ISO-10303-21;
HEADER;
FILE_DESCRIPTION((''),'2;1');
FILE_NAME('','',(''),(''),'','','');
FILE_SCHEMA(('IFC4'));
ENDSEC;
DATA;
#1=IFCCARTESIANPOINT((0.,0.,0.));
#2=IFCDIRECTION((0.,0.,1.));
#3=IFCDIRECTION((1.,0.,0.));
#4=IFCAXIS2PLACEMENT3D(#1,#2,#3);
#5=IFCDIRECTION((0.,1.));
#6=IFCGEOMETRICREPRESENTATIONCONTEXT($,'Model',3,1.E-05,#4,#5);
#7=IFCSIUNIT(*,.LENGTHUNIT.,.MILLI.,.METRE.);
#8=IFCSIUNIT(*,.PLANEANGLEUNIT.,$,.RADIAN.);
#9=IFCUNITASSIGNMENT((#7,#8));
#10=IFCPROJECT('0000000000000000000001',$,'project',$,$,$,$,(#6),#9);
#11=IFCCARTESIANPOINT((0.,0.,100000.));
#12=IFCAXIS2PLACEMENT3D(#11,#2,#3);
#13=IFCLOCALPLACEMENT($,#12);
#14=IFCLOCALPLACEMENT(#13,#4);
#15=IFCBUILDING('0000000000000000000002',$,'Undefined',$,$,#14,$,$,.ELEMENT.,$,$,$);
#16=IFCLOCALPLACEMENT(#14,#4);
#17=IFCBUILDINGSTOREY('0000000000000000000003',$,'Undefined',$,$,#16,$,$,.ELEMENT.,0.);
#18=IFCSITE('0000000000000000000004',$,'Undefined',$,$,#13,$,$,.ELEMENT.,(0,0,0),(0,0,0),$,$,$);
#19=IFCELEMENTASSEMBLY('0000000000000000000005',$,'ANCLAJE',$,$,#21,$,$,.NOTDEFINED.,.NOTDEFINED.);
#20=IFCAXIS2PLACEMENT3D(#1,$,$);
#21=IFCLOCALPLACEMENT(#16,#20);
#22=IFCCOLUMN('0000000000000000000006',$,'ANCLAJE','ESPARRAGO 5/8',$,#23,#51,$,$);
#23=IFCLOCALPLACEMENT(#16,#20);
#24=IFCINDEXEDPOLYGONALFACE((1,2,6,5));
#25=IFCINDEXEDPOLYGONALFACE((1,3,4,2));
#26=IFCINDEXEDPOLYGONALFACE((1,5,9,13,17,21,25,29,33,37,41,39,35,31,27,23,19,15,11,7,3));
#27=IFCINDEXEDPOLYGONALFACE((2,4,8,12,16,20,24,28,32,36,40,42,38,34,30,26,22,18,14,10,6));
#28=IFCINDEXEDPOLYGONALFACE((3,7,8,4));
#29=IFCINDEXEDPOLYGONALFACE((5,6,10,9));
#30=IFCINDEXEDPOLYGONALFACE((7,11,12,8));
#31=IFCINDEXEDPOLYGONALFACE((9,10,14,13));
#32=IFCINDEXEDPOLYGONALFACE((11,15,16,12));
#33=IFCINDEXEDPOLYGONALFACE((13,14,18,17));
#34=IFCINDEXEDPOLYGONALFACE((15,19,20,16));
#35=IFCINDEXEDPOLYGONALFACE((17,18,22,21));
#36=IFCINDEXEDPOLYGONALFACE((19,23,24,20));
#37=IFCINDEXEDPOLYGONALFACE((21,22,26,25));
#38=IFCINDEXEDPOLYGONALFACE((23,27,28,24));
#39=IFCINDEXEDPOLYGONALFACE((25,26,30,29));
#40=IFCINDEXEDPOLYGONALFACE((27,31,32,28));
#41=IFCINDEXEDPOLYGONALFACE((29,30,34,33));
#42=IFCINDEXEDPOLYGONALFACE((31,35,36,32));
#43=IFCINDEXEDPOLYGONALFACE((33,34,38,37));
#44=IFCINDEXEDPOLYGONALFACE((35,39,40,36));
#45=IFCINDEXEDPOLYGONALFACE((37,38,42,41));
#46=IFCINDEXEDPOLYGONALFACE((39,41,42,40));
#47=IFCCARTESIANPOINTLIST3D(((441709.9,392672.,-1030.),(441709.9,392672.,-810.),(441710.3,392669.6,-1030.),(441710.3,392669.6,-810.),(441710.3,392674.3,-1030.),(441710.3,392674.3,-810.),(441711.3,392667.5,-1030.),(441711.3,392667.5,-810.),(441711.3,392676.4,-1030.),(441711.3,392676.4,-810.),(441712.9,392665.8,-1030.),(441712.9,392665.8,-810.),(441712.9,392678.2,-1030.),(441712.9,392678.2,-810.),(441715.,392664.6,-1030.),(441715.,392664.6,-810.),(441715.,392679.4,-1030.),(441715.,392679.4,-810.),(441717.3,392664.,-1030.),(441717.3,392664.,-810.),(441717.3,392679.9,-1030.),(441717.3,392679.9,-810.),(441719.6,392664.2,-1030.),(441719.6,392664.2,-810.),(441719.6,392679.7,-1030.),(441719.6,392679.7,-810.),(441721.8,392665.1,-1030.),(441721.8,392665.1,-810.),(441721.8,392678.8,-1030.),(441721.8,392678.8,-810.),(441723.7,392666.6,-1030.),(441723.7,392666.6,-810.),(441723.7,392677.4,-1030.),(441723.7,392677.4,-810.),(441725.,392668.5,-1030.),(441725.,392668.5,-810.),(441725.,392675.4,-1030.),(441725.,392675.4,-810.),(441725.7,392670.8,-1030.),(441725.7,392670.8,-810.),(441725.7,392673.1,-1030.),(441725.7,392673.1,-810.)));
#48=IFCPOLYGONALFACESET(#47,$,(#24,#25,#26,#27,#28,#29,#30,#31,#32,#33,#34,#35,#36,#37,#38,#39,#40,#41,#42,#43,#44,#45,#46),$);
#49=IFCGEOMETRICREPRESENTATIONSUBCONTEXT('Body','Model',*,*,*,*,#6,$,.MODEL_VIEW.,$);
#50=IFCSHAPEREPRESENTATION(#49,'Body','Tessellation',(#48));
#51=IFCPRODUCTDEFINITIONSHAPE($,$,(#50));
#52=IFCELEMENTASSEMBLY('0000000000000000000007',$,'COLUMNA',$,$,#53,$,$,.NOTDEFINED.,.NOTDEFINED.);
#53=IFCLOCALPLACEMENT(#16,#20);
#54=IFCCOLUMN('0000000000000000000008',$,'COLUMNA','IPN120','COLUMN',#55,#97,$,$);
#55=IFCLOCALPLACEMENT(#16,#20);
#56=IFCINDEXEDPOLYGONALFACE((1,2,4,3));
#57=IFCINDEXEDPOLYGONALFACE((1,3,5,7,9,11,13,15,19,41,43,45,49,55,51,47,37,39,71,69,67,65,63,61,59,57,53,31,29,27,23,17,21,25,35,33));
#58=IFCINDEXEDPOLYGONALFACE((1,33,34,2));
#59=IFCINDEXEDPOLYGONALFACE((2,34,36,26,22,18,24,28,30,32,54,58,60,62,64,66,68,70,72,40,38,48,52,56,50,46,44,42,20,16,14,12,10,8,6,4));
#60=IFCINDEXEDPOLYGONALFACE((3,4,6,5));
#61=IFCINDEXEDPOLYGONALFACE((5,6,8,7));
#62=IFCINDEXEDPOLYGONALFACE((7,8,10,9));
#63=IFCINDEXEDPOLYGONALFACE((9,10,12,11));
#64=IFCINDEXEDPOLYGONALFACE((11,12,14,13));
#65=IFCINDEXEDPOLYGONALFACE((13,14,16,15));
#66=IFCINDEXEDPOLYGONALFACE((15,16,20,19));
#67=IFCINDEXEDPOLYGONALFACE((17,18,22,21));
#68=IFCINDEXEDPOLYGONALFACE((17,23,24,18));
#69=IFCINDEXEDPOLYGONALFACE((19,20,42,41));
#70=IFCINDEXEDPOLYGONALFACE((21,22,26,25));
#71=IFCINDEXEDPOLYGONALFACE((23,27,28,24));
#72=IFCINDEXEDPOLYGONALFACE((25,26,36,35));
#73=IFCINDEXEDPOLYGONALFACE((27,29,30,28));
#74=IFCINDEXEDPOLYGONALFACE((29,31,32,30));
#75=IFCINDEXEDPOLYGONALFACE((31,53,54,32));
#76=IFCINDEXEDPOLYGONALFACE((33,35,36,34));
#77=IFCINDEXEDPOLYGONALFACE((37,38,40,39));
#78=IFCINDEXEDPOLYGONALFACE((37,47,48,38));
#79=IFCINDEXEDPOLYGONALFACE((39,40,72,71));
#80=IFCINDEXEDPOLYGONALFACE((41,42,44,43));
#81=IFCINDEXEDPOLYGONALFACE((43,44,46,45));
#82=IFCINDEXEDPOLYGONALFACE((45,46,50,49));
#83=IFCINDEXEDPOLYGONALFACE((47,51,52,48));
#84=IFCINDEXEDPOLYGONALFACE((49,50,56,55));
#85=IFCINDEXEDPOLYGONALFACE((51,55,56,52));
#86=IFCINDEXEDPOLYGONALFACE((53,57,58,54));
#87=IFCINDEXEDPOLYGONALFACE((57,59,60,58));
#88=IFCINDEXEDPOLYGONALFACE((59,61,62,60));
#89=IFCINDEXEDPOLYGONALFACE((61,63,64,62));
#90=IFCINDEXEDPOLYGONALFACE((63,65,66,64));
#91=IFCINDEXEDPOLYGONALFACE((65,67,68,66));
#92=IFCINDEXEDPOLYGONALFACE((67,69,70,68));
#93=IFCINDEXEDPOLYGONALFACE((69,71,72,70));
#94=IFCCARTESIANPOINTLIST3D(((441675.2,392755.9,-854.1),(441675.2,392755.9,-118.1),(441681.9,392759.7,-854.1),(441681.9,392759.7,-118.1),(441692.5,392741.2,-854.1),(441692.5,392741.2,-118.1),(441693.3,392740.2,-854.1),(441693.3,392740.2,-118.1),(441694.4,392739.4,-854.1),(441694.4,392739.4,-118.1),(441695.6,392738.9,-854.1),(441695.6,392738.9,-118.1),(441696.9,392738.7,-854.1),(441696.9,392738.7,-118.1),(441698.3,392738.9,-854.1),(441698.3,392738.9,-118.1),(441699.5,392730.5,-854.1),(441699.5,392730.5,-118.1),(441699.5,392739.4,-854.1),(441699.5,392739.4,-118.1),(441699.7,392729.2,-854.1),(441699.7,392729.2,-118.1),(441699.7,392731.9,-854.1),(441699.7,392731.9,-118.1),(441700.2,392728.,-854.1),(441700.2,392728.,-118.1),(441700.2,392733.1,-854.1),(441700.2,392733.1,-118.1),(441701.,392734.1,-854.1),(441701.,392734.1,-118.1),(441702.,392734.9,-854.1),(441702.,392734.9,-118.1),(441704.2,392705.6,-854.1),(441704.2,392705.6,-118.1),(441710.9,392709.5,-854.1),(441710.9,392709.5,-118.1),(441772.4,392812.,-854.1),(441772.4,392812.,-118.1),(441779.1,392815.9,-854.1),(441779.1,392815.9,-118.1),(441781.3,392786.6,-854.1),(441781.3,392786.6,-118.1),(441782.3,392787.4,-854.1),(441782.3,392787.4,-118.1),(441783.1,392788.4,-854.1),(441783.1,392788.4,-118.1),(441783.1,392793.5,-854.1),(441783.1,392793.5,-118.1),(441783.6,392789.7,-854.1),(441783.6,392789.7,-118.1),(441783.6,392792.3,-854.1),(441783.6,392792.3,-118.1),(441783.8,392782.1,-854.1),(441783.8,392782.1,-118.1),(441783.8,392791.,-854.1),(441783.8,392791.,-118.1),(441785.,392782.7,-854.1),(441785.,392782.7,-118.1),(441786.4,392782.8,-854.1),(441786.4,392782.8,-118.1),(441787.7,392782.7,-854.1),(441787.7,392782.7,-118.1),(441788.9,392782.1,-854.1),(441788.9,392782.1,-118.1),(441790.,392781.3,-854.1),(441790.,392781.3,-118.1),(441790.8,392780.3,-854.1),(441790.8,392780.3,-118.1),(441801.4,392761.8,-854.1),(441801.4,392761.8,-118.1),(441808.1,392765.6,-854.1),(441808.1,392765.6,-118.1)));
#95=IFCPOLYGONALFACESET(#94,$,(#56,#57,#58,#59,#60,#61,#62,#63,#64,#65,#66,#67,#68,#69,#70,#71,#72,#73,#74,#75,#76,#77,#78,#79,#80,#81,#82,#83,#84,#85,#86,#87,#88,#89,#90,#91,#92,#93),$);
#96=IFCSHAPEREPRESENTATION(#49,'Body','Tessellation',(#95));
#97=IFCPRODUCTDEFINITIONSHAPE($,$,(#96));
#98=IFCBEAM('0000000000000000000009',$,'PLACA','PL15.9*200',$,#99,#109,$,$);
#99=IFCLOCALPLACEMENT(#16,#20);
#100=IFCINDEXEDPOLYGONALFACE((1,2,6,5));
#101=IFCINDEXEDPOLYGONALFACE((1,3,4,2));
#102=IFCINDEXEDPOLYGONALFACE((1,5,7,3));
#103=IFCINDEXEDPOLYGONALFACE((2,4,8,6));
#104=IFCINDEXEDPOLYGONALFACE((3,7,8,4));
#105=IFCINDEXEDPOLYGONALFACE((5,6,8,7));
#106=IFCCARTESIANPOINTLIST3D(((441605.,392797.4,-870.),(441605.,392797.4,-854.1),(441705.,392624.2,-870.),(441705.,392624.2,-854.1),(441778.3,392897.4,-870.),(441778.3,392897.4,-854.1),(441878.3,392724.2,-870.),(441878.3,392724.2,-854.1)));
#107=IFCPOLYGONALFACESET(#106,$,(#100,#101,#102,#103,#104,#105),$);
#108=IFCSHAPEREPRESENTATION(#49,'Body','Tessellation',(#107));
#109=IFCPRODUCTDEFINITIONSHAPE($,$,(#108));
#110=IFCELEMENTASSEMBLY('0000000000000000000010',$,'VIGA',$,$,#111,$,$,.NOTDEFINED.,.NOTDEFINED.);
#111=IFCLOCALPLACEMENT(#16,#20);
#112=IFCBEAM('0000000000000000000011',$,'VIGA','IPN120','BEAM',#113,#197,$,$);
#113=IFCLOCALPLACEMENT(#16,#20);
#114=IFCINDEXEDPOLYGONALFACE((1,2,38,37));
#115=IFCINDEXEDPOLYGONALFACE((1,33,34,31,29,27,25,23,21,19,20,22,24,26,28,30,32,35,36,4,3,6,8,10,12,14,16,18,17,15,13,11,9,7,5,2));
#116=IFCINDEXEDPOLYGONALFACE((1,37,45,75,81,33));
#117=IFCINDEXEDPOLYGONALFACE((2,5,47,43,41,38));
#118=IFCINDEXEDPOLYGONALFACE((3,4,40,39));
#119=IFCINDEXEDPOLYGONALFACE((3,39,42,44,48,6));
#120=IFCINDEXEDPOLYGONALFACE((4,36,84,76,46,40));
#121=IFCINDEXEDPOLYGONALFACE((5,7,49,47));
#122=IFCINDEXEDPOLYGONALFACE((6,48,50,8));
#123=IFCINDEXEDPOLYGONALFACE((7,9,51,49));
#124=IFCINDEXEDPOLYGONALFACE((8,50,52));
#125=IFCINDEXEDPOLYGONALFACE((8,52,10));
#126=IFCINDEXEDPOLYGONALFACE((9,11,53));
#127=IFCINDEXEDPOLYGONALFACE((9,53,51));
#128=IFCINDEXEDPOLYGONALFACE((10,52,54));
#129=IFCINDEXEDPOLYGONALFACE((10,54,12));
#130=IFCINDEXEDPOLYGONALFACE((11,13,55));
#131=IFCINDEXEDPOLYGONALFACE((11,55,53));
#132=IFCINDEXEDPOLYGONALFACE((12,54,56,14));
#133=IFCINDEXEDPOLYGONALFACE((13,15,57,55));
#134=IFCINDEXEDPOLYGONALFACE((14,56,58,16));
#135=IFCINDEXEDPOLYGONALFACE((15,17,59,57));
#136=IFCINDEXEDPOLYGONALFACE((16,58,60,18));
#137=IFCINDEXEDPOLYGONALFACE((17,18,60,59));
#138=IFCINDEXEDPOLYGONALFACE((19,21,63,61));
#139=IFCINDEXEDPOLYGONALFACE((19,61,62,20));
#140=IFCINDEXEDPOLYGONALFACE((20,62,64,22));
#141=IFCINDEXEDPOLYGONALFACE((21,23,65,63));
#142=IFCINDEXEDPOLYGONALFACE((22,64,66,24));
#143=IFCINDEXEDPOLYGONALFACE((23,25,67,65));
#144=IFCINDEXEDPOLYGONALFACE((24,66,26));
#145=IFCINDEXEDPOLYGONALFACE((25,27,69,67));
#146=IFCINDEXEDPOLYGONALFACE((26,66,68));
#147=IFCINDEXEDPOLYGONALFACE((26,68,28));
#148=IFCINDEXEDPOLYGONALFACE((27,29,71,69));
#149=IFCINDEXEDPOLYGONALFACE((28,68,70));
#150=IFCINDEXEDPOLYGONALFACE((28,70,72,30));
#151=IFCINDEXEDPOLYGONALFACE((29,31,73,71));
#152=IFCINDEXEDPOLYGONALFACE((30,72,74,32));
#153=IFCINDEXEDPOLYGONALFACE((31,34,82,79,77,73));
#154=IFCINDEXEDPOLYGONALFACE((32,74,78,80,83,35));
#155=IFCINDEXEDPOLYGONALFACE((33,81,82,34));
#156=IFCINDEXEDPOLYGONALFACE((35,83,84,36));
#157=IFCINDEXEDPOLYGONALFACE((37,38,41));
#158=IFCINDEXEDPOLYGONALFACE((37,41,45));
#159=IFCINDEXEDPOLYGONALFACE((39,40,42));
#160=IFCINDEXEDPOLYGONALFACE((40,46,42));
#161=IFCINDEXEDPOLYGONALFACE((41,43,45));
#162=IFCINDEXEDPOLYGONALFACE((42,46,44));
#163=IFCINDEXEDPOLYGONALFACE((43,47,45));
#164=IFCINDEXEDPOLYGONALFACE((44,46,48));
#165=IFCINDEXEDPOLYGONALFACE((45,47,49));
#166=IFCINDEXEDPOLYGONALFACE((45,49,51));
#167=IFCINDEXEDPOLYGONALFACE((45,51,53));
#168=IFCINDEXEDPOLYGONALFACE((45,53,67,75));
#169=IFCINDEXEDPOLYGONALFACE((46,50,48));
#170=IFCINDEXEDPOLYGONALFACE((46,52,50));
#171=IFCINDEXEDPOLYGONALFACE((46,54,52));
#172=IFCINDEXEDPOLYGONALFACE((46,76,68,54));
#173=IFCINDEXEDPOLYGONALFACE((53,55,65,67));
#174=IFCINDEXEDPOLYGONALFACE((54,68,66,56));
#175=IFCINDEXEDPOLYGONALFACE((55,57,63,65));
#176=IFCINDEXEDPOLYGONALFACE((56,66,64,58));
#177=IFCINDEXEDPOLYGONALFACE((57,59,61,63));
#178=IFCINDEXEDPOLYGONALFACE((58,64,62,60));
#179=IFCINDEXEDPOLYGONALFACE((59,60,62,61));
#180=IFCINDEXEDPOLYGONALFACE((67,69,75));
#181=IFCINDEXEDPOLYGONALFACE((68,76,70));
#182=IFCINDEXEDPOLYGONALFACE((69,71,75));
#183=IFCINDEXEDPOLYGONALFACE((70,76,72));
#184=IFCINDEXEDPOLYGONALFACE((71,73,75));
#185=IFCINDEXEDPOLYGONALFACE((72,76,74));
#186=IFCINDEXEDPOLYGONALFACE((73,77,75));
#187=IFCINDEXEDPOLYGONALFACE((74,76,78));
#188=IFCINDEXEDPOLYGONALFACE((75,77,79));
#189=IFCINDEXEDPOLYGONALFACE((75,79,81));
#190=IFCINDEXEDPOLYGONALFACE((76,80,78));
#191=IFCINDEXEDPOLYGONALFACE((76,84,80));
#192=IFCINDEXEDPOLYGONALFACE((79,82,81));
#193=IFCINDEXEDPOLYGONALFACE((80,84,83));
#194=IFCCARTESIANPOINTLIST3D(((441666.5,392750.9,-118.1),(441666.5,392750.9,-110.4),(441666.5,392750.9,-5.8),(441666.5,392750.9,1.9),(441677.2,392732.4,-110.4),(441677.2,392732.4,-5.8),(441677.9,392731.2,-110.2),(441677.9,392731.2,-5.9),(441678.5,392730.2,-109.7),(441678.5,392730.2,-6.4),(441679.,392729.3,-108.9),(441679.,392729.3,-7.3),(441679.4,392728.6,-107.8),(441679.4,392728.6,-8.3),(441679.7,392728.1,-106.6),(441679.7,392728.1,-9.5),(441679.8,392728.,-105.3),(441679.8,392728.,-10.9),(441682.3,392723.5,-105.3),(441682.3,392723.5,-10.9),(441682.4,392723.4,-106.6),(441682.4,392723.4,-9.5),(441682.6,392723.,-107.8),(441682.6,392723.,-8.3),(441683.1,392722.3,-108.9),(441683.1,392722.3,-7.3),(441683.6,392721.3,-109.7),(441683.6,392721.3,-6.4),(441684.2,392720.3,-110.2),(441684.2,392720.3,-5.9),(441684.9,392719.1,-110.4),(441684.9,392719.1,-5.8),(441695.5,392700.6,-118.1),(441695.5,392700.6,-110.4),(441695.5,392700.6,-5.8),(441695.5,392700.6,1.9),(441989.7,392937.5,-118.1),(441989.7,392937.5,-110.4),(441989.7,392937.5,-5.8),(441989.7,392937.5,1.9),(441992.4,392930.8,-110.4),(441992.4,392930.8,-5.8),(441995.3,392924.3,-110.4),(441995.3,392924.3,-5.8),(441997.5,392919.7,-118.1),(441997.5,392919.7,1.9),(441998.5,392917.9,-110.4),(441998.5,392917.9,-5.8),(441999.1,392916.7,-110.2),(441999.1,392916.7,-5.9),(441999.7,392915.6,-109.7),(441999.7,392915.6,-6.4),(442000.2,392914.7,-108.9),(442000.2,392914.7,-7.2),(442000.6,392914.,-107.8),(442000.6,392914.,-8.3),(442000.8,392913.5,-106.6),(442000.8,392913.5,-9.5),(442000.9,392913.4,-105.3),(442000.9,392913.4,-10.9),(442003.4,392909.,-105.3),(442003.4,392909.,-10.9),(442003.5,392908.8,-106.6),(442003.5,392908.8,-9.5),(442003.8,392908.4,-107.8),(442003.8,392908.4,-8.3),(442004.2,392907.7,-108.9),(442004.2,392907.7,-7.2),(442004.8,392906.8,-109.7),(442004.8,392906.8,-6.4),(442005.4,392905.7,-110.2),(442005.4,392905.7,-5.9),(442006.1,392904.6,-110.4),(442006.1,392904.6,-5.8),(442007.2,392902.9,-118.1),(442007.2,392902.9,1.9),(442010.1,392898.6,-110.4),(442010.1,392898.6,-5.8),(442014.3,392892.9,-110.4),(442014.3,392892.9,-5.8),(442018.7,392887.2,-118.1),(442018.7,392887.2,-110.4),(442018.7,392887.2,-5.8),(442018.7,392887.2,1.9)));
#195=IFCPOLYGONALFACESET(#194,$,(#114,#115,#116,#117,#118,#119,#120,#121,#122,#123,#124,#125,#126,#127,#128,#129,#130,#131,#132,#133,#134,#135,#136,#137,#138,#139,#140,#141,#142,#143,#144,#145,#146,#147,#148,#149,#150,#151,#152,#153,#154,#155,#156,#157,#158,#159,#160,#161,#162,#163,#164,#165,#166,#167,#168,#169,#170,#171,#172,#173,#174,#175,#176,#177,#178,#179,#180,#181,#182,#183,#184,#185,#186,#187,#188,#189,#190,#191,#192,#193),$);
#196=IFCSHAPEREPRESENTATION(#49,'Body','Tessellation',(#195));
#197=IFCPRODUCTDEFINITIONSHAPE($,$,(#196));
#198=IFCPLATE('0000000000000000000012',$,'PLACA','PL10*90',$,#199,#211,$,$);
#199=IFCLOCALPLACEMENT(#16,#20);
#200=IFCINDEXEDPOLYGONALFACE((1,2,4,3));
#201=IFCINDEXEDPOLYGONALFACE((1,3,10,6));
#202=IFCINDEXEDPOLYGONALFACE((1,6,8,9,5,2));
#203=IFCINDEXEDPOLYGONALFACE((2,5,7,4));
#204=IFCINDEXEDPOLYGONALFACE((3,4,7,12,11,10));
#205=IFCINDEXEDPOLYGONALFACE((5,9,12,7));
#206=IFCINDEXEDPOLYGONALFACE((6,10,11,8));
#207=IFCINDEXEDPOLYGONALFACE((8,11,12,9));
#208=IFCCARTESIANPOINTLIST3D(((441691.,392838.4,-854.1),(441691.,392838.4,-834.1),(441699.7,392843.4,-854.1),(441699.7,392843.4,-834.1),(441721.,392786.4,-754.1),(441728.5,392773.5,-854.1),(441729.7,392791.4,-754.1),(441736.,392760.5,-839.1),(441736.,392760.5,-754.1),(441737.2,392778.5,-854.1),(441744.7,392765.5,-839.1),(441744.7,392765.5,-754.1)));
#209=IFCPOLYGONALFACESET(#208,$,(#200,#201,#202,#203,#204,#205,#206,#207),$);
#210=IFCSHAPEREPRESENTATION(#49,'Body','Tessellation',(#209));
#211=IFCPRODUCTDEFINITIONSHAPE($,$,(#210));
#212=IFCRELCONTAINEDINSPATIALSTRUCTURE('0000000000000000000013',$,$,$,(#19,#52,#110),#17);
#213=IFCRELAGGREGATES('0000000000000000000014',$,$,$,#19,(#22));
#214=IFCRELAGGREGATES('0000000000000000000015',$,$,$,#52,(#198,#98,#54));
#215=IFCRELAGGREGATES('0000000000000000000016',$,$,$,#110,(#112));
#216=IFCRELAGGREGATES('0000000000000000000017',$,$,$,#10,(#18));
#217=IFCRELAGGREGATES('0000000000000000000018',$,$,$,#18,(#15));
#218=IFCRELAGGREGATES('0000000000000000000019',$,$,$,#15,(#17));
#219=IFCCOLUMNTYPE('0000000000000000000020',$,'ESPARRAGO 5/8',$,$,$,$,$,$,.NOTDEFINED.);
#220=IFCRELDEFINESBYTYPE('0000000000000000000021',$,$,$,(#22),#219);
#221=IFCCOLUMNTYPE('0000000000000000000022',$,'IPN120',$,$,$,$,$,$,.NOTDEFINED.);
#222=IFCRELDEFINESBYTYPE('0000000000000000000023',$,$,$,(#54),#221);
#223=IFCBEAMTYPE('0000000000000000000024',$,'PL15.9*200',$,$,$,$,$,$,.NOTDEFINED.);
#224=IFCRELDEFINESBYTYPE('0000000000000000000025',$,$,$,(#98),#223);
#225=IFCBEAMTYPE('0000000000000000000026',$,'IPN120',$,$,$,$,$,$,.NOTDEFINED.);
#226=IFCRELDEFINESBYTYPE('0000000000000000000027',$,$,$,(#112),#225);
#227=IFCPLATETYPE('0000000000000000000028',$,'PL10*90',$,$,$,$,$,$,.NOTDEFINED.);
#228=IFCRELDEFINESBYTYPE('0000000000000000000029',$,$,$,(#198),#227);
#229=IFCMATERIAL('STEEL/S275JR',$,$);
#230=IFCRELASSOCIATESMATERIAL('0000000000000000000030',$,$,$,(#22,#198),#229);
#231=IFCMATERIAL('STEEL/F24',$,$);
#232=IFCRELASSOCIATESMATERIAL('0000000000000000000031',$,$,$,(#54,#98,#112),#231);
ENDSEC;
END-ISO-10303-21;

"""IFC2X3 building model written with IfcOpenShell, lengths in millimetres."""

from ifc_helpers import new_model, si_unit, direction, frame, origin_with_axes, origin_2d_with_axis, place, context, subcontext, project, spatial, polyline, rectangle, circle, i_section, outline, extrude, boolean, clip, halfspace, material, type_object, element, aggregate, save


model = new_model("IFC2X3")

# Units and contexts
model_context = context("Model", 3, precision=1e-05, world=origin_with_axes(), true_north=direction((0.0, 1.0)))
body_context = subcontext(model_context, "Body", "Model", "MODEL_VIEW")
ifc_project = project(units=[si_unit("LENGTHUNIT", "METRE", prefix="MILLI"), si_unit("PLANEANGLEUNIT", "RADIAN")], contexts=[model_context])

# Site, building, storey
site_placement = place(None, frame((0.0, 0.0, 100000.0), z_axis=(0.0, 0.0, 1.0), x_axis=(1.0, 0.0, 0.0)))
site = spatial("IfcSite", under=ifc_project, at=site_placement, Name="Undefined", CompositionType="ELEMENT", RefLatitude=(0, 0, 0), RefLongitude=(0, 0, 0))
building_placement = place(site_placement, origin_with_axes())
building = spatial("IfcBuilding", under=site, at=building_placement, Name="Undefined", CompositionType="ELEMENT")
storey_placement = place(building_placement, origin_with_axes())
storey = spatial("IfcBuildingStorey", under=building, at=storey_placement, Name="Undefined", CompositionType="ELEMENT", Elevation=0.0)

# Element assembly
ifc_material_1 = material(Name="STEEL/S275JR")
assembly_1_placement = place(storey_placement, origin_with_axes())
assembly_1 = element("IfcElementAssembly", 1, at=assembly_1_placement, inside=storey, Name="ANCLAJE", AssemblyPlace="NOTDEFINED", PredefinedType="NOTDEFINED")

# Column
column_type_1 = type_object("IfcColumnType", Name="ESPARRAGO 5/8", PredefinedType="NOTDEFINED")
column_1_placement = place(assembly_1_placement, frame((441717.9, 392672.0, -810.0), z_axis=(0.0, 0.0, -1.0), x_axis=(0.866025, 0.5, 0.0)))
column_1 = element("IfcColumn", 2, at=column_1_placement, type_object=column_type_1, material=ifc_material_1, Name="ANCLAJE", Description="ESPARRAGO 5/8", context=body_context, shape_type="SweptSolid", body=[
    extrude(circle(Radius=7.9, at=origin_2d_with_axis()), frame((0.0, 0.0, 220.0), z_axis=(0.0, 0.0, -1.0), x_axis=(0.0, 1.0, 0.0)), (0.0, 0.0, 1.0), 220.0),
])
aggregate(assembly_1, [column_1])

# Element assembly, column, beam
assembly_2_placement = place(storey_placement, origin_with_axes())
assembly_2 = element("IfcElementAssembly", 3, at=assembly_2_placement, inside=storey, Name="COLUMNA", AssemblyPlace="NOTDEFINED", PredefinedType="NOTDEFINED")
ifc_material_2 = material(Name="STEEL/F24")
column_type_2 = type_object("IfcColumnType", Name="IPN120", PredefinedType="NOTDEFINED")
column_2_placement = place(assembly_2_placement, frame((441741.6, 392760.8, -880.0), z_axis=(0.0, 0.0, 1.0), x_axis=(0.866025, 0.5, 0.0)))
column_2 = element("IfcColumn", 4, at=column_2_placement, type_object=column_type_2, material=ifc_material_2, Name="COLUMNA", Description="IPN120", ObjectType="COLUMN", context=body_context, shape_type="Clipping", body=[
    clip(extrude(i_section(OverallWidth=58.0, OverallDepth=120.0, WebThickness=5.1, FlangeThickness=7.7, FilletRadius=5.1, at=origin_2d_with_axis()), frame((0.0, 0.0, 761.9), z_axis=(0.0, 0.0, -1.0), x_axis=(0.0, 1.0, 0.0)), (0.0, 0.0, 1.0), 761.9), halfspace(frame((-60.0, 0.0, 25.9), z_axis=(0.0, 0.0, 1.0), x_axis=(0.0, 1.0, 0.0)), True)),
])
beam_type_1 = type_object("IfcBeamType", Name="PL15.9*200", PredefinedType="NOTDEFINED")
beam_1_placement = place(assembly_2_placement, frame((441655.0, 392710.8, -862.1), z_axis=(-0.5, 0.866025, 0.0), x_axis=(0.866025, 0.5, 0.0)))
beam_1 = element("IfcBeam", 5, at=beam_1_placement, type_object=beam_type_1, material=ifc_material_2, Name="PLACA", Description="PL15.9*200", context=body_context, shape_type="SweptSolid", body=[
    extrude(rectangle(XDim=15.9, YDim=200.0, at=origin_2d_with_axis()), frame((200.0, 0.0, 0.0), z_axis=(-1.0, 0.0, 0.0), x_axis=(0.0, -1.0, 0.0)), (0.0, 0.0, 1.0), 200.0),
])

# Element assembly, beam
assembly_3_placement = place(storey_placement, origin_with_axes())
assembly_3 = element("IfcElementAssembly", 6, at=assembly_3_placement, inside=storey, Name="VIGA", AssemblyPlace="NOTDEFINED", PredefinedType="NOTDEFINED")
beam_type_2 = type_object("IfcBeamType", Name="IPN120", PredefinedType="NOTDEFINED")
beam_2_placement = place(assembly_3_placement, frame((441681.0, 392725.8, -58.1), z_axis=(0.0, 0.0, 1.0), x_axis=(0.866025, 0.5, 0.0)))
beam_2 = element("IfcBeam", 7, at=beam_2_placement, type_object=beam_type_2, material=ifc_material_2, Name="VIGA", Description="IPN120", ObjectType="BEAM", context=body_context, shape_type="CSG", body=[
    boolean("DIFFERENCE", extrude(i_section(OverallWidth=58.0, OverallDepth=120.0, WebThickness=5.1, FlangeThickness=7.7, FilletRadius=5.1, at=origin_2d_with_axis()), frame((380.0, 0.0, 0.0), z_axis=(-1.0, 0.0, 0.0), x_axis=(0.0, -1.0, 0.0)), (0.0, 0.0, 1.0), 380.0), extrude(circle(Radius=177.8, at=origin_2d_with_axis()), frame((548.6, 0.0, 60.0), z_axis=(0.0, 0.0, -1.0), x_axis=(1.0, 0.0, 0.0)), (0.0, 0.0, 1.0), 120.0)),
])

# Plate
plate_type_1 = type_object("IfcPlateType", Name="PL10*90", PredefinedType="NOTDEFINED")
plate_1_placement = place(assembly_2_placement, frame((441740.4, 392763.0, -839.1), z_axis=(0.866025, 0.5, 0.0), x_axis=(-0.353553, 0.612372, -0.707107)))
plate_1 = element("IfcPlate", 8, at=plate_1_placement, type_object=plate_type_1, material=ifc_material_1, Name="PLACA", Description="PL10*90", context=body_context, shape_type="SweptSolid", body=[
    extrude(outline(polyline([(0.0, 0.0), (21.2, 0.0), (74.2, 53.0), (60.1, 67.2), (-38.9, 81.3), (-60.1, 60.1), (0.0, 0.0)])), frame((0.0, 0.0, -5.0), z_axis=(0.0, 0.0, 1.0), x_axis=(1.0, 0.0, 0.0)), (0.0, 0.0, 1.0), 10.0),
])
aggregate(assembly_2, [plate_1, beam_1, column_2])
aggregate(assembly_3, [beam_2])

save(model, "model.ifc")
